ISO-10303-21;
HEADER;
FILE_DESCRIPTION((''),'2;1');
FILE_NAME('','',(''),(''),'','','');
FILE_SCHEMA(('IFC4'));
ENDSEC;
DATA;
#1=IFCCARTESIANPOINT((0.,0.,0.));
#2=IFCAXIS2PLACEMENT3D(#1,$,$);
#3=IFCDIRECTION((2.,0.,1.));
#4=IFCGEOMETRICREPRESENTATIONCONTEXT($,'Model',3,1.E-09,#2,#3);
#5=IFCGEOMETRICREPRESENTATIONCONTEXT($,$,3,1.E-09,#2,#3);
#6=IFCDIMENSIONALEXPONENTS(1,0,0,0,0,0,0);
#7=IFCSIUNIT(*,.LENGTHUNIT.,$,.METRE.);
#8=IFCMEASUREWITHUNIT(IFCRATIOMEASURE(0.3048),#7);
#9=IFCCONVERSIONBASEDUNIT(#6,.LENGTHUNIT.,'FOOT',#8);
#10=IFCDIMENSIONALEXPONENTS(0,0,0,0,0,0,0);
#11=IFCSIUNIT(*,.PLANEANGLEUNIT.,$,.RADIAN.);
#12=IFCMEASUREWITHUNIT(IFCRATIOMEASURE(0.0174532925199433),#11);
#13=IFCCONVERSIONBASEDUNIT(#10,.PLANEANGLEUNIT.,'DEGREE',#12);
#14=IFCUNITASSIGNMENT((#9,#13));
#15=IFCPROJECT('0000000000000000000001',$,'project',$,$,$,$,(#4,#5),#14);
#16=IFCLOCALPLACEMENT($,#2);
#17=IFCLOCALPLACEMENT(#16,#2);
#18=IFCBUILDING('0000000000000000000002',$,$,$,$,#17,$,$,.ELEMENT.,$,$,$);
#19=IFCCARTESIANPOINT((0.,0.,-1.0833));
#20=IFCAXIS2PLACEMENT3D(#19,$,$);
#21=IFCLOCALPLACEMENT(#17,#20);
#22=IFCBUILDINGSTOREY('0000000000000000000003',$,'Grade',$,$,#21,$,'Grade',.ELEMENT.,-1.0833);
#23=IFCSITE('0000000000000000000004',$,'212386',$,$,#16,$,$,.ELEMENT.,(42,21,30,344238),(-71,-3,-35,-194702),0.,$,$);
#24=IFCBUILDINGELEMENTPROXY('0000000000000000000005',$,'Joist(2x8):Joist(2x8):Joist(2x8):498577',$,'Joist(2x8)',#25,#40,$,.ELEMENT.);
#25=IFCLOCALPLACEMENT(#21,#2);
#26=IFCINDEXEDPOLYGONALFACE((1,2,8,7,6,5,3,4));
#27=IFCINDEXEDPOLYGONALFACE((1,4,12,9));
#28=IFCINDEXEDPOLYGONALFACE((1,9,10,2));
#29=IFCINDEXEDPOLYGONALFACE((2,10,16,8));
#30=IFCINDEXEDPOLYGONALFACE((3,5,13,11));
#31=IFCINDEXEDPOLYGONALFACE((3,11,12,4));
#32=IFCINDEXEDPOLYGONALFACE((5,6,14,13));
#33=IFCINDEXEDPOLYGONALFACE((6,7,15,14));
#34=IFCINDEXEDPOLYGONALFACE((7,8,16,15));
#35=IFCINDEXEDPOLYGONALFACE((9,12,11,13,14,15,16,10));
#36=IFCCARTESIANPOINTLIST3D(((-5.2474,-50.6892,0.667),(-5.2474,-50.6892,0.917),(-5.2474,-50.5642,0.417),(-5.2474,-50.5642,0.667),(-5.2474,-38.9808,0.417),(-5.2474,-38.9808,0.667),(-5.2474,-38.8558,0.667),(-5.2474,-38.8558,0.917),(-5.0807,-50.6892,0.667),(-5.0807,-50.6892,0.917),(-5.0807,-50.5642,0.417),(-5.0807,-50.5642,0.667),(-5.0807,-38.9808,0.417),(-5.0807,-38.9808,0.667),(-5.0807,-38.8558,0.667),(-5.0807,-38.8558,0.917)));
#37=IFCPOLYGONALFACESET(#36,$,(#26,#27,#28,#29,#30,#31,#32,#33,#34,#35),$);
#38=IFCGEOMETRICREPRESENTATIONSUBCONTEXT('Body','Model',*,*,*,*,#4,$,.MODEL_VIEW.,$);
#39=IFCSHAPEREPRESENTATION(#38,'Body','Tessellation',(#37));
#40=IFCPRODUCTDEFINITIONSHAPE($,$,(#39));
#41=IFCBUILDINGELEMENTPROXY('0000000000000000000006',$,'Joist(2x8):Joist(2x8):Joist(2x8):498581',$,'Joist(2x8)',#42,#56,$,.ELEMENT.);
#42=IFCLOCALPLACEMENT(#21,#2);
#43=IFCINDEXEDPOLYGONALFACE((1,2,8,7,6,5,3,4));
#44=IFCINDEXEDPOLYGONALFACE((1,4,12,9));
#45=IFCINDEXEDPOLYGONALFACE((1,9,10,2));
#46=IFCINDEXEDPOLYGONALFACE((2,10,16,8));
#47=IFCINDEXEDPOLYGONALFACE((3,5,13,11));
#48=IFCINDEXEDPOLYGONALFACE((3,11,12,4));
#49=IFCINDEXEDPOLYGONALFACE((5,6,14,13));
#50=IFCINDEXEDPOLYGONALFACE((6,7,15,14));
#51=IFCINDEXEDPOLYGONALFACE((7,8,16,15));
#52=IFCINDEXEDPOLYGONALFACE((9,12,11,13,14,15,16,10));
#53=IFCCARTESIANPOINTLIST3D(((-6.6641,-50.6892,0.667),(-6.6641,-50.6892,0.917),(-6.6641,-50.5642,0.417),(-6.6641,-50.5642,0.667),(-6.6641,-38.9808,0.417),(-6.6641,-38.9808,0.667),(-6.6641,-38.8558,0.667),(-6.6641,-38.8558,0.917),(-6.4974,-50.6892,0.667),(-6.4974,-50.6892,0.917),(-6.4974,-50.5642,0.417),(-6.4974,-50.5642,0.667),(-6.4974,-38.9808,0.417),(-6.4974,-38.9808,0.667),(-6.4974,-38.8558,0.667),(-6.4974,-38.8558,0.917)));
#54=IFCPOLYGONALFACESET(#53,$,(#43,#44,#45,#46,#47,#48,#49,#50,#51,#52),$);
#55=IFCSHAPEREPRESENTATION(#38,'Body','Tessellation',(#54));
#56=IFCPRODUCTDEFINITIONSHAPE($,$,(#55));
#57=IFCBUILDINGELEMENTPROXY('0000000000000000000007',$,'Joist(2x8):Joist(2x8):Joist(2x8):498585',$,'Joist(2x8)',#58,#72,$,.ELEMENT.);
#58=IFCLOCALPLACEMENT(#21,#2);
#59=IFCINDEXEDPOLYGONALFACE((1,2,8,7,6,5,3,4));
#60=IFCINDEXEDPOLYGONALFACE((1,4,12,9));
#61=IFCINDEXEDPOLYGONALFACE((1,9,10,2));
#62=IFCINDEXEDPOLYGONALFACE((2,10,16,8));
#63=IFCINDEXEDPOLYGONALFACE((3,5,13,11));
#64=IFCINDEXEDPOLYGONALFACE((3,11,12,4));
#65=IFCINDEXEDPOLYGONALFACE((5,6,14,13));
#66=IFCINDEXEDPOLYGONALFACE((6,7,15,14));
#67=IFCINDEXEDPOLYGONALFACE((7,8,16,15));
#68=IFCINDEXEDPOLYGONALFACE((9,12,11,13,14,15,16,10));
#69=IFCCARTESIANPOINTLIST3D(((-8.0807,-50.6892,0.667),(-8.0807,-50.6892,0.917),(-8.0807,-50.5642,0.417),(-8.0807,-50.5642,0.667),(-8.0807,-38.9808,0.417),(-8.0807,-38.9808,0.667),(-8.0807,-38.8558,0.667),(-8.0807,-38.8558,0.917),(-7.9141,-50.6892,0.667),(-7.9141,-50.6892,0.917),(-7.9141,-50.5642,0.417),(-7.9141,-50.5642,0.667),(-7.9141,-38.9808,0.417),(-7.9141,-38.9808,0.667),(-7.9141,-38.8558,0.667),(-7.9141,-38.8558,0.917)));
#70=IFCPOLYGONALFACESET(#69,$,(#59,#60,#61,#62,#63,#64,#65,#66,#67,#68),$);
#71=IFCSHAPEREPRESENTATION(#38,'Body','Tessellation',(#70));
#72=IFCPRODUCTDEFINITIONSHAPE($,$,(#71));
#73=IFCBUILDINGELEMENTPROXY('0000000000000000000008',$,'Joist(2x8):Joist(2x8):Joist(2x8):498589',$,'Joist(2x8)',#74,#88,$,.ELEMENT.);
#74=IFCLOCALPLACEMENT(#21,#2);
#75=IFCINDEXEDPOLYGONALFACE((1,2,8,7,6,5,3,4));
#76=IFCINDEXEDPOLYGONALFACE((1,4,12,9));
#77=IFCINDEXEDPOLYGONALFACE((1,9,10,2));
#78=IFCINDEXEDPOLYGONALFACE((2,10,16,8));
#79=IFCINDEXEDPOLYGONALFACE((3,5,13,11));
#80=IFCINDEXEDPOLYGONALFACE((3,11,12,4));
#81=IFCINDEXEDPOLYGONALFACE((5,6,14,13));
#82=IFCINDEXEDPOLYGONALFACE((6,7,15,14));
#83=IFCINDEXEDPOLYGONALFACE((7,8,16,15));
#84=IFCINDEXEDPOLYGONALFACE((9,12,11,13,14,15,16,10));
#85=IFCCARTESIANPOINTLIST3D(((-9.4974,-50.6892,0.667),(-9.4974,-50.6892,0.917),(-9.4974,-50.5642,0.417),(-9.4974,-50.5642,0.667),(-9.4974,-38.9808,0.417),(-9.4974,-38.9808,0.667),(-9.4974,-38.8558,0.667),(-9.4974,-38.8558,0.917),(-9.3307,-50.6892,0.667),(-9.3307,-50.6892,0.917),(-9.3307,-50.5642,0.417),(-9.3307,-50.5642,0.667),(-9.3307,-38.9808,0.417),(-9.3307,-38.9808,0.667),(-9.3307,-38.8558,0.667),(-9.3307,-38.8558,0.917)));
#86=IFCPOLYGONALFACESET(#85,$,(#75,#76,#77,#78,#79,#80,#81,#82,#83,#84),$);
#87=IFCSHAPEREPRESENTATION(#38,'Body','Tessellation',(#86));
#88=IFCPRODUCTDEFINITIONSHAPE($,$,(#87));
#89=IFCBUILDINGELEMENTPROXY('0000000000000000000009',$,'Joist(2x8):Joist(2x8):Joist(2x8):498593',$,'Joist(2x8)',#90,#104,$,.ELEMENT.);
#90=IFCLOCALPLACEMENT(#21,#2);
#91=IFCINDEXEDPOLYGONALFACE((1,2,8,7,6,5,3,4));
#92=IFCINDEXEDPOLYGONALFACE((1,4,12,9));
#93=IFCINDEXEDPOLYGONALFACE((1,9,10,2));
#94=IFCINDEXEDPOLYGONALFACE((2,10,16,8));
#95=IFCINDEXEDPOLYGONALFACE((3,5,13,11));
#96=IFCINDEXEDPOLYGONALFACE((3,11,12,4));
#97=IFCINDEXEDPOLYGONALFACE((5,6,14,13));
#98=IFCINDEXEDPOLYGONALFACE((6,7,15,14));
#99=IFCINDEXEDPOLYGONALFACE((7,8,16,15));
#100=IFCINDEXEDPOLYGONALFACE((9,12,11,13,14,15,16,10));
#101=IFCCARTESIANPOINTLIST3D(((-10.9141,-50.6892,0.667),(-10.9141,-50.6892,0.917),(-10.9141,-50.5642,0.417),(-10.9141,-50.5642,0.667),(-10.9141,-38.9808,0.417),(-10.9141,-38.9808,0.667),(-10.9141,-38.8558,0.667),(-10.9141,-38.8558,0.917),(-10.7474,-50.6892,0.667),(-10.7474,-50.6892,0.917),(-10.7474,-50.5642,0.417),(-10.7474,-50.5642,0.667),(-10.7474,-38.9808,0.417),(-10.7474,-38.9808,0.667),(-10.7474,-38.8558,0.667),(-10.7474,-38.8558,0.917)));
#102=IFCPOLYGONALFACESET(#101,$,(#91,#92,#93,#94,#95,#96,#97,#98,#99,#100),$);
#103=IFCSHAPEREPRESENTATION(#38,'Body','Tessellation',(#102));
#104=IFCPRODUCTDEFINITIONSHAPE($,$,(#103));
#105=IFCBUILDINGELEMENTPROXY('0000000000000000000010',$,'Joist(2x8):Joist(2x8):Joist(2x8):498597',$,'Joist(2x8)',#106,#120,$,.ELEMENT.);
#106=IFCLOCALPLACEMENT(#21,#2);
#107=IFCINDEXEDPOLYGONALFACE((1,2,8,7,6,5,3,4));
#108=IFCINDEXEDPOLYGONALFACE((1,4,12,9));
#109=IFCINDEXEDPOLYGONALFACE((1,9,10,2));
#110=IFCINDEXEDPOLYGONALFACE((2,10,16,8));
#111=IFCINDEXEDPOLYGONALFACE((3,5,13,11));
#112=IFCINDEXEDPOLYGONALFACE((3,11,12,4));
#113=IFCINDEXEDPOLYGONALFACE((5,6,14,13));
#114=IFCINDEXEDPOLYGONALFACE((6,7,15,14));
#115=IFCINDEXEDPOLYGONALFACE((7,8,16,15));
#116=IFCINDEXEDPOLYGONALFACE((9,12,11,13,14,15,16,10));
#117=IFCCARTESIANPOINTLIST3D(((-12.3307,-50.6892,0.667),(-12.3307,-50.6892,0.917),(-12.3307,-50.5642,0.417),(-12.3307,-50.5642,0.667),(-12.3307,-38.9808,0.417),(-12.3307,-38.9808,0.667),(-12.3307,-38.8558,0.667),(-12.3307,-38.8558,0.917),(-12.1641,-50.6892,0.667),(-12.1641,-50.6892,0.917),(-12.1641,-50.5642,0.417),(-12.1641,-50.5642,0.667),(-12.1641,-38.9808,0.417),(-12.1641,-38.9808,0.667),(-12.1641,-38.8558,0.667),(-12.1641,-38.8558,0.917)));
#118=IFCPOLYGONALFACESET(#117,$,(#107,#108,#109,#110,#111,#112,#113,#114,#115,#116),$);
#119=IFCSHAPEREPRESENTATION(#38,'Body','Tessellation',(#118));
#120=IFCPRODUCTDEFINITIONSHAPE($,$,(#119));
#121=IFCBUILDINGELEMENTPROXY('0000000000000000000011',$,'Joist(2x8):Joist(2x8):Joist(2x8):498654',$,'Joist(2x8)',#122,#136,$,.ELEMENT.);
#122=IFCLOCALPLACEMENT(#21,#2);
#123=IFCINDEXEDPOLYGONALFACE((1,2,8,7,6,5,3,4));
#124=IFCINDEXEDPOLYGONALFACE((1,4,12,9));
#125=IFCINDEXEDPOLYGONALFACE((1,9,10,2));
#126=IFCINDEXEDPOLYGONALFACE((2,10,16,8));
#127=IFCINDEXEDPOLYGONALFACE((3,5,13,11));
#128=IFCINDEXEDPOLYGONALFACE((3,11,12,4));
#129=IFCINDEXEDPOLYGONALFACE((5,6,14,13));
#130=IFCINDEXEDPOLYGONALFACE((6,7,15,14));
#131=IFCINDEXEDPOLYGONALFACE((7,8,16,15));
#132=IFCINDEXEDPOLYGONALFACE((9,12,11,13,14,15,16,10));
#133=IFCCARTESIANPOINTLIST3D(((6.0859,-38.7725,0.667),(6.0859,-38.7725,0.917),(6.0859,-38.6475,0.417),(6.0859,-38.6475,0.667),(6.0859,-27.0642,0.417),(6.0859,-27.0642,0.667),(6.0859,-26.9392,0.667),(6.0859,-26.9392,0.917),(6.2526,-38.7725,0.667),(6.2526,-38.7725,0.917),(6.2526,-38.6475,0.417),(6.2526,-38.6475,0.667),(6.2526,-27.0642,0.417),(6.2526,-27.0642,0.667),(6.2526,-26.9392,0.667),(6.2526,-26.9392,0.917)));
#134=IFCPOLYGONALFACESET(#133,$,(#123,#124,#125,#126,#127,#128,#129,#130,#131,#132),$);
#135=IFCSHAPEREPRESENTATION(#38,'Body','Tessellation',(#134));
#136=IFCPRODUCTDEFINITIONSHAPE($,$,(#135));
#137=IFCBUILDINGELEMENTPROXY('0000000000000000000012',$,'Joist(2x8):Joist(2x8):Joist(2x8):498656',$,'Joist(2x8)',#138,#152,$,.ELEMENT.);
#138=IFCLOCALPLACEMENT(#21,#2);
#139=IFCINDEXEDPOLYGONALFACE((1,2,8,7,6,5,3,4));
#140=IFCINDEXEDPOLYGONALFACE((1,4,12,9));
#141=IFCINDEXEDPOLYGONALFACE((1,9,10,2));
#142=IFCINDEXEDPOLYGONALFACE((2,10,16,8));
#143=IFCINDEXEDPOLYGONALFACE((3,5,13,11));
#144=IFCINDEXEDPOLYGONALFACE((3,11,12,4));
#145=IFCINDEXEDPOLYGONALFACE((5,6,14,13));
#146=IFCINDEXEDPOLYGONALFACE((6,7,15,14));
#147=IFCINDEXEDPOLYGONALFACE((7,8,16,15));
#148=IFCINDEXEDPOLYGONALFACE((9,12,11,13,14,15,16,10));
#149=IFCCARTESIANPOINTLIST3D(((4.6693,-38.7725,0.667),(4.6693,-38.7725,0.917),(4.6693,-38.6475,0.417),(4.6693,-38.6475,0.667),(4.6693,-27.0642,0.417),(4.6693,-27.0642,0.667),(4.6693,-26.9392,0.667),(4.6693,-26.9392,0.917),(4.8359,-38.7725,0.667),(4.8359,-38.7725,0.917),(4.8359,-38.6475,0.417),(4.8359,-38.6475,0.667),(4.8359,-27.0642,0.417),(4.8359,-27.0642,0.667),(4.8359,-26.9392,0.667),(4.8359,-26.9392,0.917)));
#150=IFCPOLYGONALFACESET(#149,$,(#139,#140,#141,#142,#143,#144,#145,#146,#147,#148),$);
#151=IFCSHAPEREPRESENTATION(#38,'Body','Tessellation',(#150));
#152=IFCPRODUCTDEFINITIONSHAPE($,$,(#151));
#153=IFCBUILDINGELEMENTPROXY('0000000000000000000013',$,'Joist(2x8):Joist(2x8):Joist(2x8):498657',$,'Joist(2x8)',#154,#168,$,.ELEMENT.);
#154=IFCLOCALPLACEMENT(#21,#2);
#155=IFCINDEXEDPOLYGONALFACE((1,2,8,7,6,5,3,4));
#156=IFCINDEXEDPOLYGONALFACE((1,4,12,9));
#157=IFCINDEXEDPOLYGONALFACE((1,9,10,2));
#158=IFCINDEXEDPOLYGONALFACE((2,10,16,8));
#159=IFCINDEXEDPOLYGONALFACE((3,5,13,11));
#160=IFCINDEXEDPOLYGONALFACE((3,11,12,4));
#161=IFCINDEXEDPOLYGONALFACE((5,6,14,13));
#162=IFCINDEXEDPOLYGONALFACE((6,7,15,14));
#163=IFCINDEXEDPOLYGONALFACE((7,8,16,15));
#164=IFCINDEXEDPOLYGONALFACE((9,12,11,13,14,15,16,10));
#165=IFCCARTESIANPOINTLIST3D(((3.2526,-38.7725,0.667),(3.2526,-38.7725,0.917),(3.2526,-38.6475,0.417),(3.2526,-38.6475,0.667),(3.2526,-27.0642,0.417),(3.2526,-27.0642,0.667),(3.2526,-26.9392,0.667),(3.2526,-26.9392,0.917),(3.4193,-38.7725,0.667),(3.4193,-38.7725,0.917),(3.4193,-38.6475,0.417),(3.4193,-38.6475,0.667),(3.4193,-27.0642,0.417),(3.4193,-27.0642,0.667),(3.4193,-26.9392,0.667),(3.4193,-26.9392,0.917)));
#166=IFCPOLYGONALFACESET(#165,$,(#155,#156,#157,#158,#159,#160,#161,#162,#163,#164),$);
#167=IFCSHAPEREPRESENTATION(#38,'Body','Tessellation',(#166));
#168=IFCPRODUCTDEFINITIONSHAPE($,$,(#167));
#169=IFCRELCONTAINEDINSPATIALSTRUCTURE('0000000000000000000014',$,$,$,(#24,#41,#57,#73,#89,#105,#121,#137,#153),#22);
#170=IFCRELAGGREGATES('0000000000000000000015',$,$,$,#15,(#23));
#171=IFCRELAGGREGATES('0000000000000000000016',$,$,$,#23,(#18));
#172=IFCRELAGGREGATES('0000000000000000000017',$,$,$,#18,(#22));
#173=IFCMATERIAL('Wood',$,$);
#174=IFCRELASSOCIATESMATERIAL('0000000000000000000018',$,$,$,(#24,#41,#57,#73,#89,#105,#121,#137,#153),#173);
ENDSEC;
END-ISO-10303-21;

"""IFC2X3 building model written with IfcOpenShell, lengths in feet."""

from ifc_helpers import new_model, entity, si_unit, converted_unit, direction, frame, origin, place, context, subcontext, project, spatial, polyline, outline, extrude, source, transform, mapped, material, element, save


model = new_model("IFC2X3")

# Units and contexts
model_context = context("Model", 3, precision=1e-09, world=origin(), true_north=direction((2.0, 0.0, 1.0)))
context_of_model = context(None, 3, precision=1e-09, world=origin(), true_north=direction((2.0, 0.0, 1.0)))
body_context = subcontext(model_context, "Body", "Model", "MODEL_VIEW")
ifc_project = project(units=[converted_unit("LENGTHUNIT", "FOOT", entity("IfcRatioMeasure", 0.3048), si_unit("LENGTHUNIT", "METRE"), dimensions=[1, 0, 0, 0, 0, 0, 0]), converted_unit("PLANEANGLEUNIT", "DEGREE", entity("IfcRatioMeasure", 0.0174532925199433), si_unit("PLANEANGLEUNIT", "RADIAN"), dimensions=[0, 0, 0, 0, 0, 0, 0])], contexts=[model_context, context_of_model])

# Site, building, storey
site_placement = place(None, origin())
site = spatial("IfcSite", under=ifc_project, at=site_placement, Name="212386", CompositionType="ELEMENT", RefLatitude=(42, 21, 30, 344238), RefLongitude=(-71, -3, -35, -194702), RefElevation=0.0)
building_placement = place(site_placement, origin())
building = spatial("IfcBuilding", under=site, at=building_placement, CompositionType="ELEMENT")
storey_placement = place(building_placement, frame((0.0, 0.0, -1.0833)))
storey = spatial("IfcBuildingStorey", under=building, at=storey_placement, Name="Grade", LongName="Grade", CompositionType="ELEMENT", Elevation=-1.0833)

# Building element proxies
ifc_material_1 = material(Name="Wood")
shared_shape_1 = source(origin(), body_context, "Body", "SweptSolid", [
    extrude(outline(polyline([(-0.25, -5.9167), (0.0, -5.9167), (0.0, -5.7917), (0.25, -5.7917), (0.25, 5.7917), (0.0, 5.7917), (0.0, 5.9167), (-0.25, 5.9167), (-0.25, -5.9167)])), frame((-5.2474, -44.7725, -0.4164), z_axis=(1.0, 0.0, 0.0), x_axis=(0.0, 0.0, -1.0)), (0.0, 0.0, 1.0), 0.1667),
])
proxy_1_placement = place(storey_placement, frame((0.0, 0.0, 1.0833)))
element("IfcBuildingElementProxy", 1, at=proxy_1_placement, inside=storey, material=ifc_material_1, Name="Joist(2x8):Joist(2x8):Joist(2x8):498577", ObjectType="Joist(2x8)", CompositionType="ELEMENT", context=body_context, shape_type="MappedRepresentation", body=[
    mapped(shared_shape_1, transform((0.0, 0.0, 0.0), scale=1.0)),
])
shared_shape_2 = source(origin(), body_context, "Body", "SweptSolid", [
    extrude(outline(polyline([(-0.25, -5.9167), (0.0, -5.9167), (0.0, -5.7917), (0.25, -5.7917), (0.25, 5.7917), (0.0, 5.7917), (0.0, 5.9167), (-0.25, 5.9167), (-0.25, -5.9167)])), frame((-6.6641, -44.7725, -0.4164), z_axis=(1.0, 0.0, 0.0), x_axis=(0.0, 0.0, -1.0)), (0.0, 0.0, 1.0), 0.1667),
])
proxy_2_placement = place(storey_placement, frame((0.0, 0.0, 1.0833)))
element("IfcBuildingElementProxy", 2, at=proxy_2_placement, inside=storey, material=ifc_material_1, Name="Joist(2x8):Joist(2x8):Joist(2x8):498581", ObjectType="Joist(2x8)", CompositionType="ELEMENT", context=body_context, shape_type="MappedRepresentation", body=[
    mapped(shared_shape_2, transform((0.0, 0.0, 0.0), scale=1.0)),
])
shared_shape_3 = source(origin(), body_context, "Body", "SweptSolid", [
    extrude(outline(polyline([(-0.25, -5.9167), (0.0, -5.9167), (0.0, -5.7917), (0.25, -5.7917), (0.25, 5.7917), (0.0, 5.7917), (0.0, 5.9167), (-0.25, 5.9167), (-0.25, -5.9167)])), frame((-8.0807, -44.7725, -0.4164), z_axis=(1.0, 0.0, 0.0), x_axis=(0.0, 0.0, -1.0)), (0.0, 0.0, 1.0), 0.1667),
])
proxy_3_placement = place(storey_placement, frame((0.0, 0.0, 1.0833)))
element("IfcBuildingElementProxy", 3, at=proxy_3_placement, inside=storey, material=ifc_material_1, Name="Joist(2x8):Joist(2x8):Joist(2x8):498585", ObjectType="Joist(2x8)", CompositionType="ELEMENT", context=body_context, shape_type="MappedRepresentation", body=[
    mapped(shared_shape_3, transform((0.0, 0.0, 0.0), scale=1.0)),
])
shared_shape_4 = source(origin(), body_context, "Body", "SweptSolid", [
    extrude(outline(polyline([(-0.25, -5.9167), (0.0, -5.9167), (0.0, -5.7917), (0.25, -5.7917), (0.25, 5.7917), (0.0, 5.7917), (0.0, 5.9167), (-0.25, 5.9167), (-0.25, -5.9167)])), frame((-9.4974, -44.7725, -0.4164), z_axis=(1.0, 0.0, 0.0), x_axis=(0.0, 0.0, -1.0)), (0.0, 0.0, 1.0), 0.1667),
])
proxy_4_placement = place(storey_placement, frame((0.0, 0.0, 1.0833)))
element("IfcBuildingElementProxy", 4, at=proxy_4_placement, inside=storey, material=ifc_material_1, Name="Joist(2x8):Joist(2x8):Joist(2x8):498589", ObjectType="Joist(2x8)", CompositionType="ELEMENT", context=body_context, shape_type="MappedRepresentation", body=[
    mapped(shared_shape_4, transform((0.0, 0.0, 0.0), scale=1.0)),
])
shared_shape_5 = source(origin(), body_context, "Body", "SweptSolid", [
    extrude(outline(polyline([(-0.25, -5.9167), (0.0, -5.9167), (0.0, -5.7917), (0.25, -5.7917), (0.25, 5.7917), (0.0, 5.7917), (0.0, 5.9167), (-0.25, 5.9167), (-0.25, -5.9167)])), frame((-10.9141, -44.7725, -0.4164), z_axis=(1.0, 0.0, 0.0), x_axis=(0.0, 0.0, -1.0)), (0.0, 0.0, 1.0), 0.1667),
])
proxy_5_placement = place(storey_placement, frame((0.0, 0.0, 1.0833)))
element("IfcBuildingElementProxy", 5, at=proxy_5_placement, inside=storey, material=ifc_material_1, Name="Joist(2x8):Joist(2x8):Joist(2x8):498593", ObjectType="Joist(2x8)", CompositionType="ELEMENT", context=body_context, shape_type="MappedRepresentation", body=[
    mapped(shared_shape_5, transform((0.0, 0.0, 0.0), scale=1.0)),
])
shared_shape_6 = source(origin(), body_context, "Body", "SweptSolid", [
    extrude(outline(polyline([(-0.25, -5.9167), (0.0, -5.9167), (0.0, -5.7917), (0.25, -5.7917), (0.25, 5.7917), (0.0, 5.7917), (0.0, 5.9167), (-0.25, 5.9167), (-0.25, -5.9167)])), frame((-12.3307, -44.7725, -0.4164), z_axis=(1.0, 0.0, 0.0), x_axis=(0.0, 0.0, -1.0)), (0.0, 0.0, 1.0), 0.1667),
])
proxy_6_placement = place(storey_placement, frame((0.0, 0.0, 1.0833)))
element("IfcBuildingElementProxy", 6, at=proxy_6_placement, inside=storey, material=ifc_material_1, Name="Joist(2x8):Joist(2x8):Joist(2x8):498597", ObjectType="Joist(2x8)", CompositionType="ELEMENT", context=body_context, shape_type="MappedRepresentation", body=[
    mapped(shared_shape_6, transform((0.0, 0.0, 0.0), scale=1.0)),
])
shared_shape_7 = source(origin(), body_context, "Body", "SweptSolid", [
    extrude(outline(polyline([(-0.25, -5.9167), (0.0, -5.9167), (0.0, -5.7917), (0.25, -5.7917), (0.25, 5.7917), (0.0, 5.7917), (0.0, 5.9167), (-0.25, 5.9167), (-0.25, -5.9167)])), frame((6.0859, -32.8558, -0.4164), z_axis=(1.0, 0.0, 0.0), x_axis=(0.0, 0.0, -1.0)), (0.0, 0.0, 1.0), 0.1667),
])
proxy_7_placement = place(storey_placement, frame((0.0, 0.0, 1.0833)))
element("IfcBuildingElementProxy", 7, at=proxy_7_placement, inside=storey, material=ifc_material_1, Name="Joist(2x8):Joist(2x8):Joist(2x8):498654", ObjectType="Joist(2x8)", CompositionType="ELEMENT", context=body_context, shape_type="MappedRepresentation", body=[
    mapped(shared_shape_7, transform((0.0, 0.0, 0.0), scale=1.0)),
])
shared_shape_8 = source(origin(), body_context, "Body", "SweptSolid", [
    extrude(outline(polyline([(-0.25, -5.9167), (0.0, -5.9167), (0.0, -5.7917), (0.25, -5.7917), (0.25, 5.7917), (0.0, 5.7917), (0.0, 5.9167), (-0.25, 5.9167), (-0.25, -5.9167)])), frame((4.6693, -32.8558, -0.4164), z_axis=(1.0, 0.0, 0.0), x_axis=(0.0, 0.0, -1.0)), (0.0, 0.0, 1.0), 0.1667),
])
proxy_8_placement = place(storey_placement, frame((0.0, 0.0, 1.0833)))
element("IfcBuildingElementProxy", 8, at=proxy_8_placement, inside=storey, material=ifc_material_1, Name="Joist(2x8):Joist(2x8):Joist(2x8):498656", ObjectType="Joist(2x8)", CompositionType="ELEMENT", context=body_context, shape_type="MappedRepresentation", body=[
    mapped(shared_shape_8, transform((0.0, 0.0, 0.0), scale=1.0)),
])
shared_shape_9 = source(origin(), body_context, "Body", "SweptSolid", [
    extrude(outline(polyline([(-0.25, -5.9167), (0.0, -5.9167), (0.0, -5.7917), (0.25, -5.7917), (0.25, 5.7917), (0.0, 5.7917), (0.0, 5.9167), (-0.25, 5.9167), (-0.25, -5.9167)])), frame((3.2526, -32.8558, -0.4164), z_axis=(1.0, 0.0, 0.0), x_axis=(0.0, 0.0, -1.0)), (0.0, 0.0, 1.0), 0.1667),
])
proxy_9_placement = place(storey_placement, frame((0.0, 0.0, 1.0833)))
element("IfcBuildingElementProxy", 9, at=proxy_9_placement, inside=storey, material=ifc_material_1, Name="Joist(2x8):Joist(2x8):Joist(2x8):498657", ObjectType="Joist(2x8)", CompositionType="ELEMENT", context=body_context, shape_type="MappedRepresentation", body=[
    mapped(shared_shape_9, transform((0.0, 0.0, 0.0), scale=1.0)),
])

save(model, "model.ifc")
